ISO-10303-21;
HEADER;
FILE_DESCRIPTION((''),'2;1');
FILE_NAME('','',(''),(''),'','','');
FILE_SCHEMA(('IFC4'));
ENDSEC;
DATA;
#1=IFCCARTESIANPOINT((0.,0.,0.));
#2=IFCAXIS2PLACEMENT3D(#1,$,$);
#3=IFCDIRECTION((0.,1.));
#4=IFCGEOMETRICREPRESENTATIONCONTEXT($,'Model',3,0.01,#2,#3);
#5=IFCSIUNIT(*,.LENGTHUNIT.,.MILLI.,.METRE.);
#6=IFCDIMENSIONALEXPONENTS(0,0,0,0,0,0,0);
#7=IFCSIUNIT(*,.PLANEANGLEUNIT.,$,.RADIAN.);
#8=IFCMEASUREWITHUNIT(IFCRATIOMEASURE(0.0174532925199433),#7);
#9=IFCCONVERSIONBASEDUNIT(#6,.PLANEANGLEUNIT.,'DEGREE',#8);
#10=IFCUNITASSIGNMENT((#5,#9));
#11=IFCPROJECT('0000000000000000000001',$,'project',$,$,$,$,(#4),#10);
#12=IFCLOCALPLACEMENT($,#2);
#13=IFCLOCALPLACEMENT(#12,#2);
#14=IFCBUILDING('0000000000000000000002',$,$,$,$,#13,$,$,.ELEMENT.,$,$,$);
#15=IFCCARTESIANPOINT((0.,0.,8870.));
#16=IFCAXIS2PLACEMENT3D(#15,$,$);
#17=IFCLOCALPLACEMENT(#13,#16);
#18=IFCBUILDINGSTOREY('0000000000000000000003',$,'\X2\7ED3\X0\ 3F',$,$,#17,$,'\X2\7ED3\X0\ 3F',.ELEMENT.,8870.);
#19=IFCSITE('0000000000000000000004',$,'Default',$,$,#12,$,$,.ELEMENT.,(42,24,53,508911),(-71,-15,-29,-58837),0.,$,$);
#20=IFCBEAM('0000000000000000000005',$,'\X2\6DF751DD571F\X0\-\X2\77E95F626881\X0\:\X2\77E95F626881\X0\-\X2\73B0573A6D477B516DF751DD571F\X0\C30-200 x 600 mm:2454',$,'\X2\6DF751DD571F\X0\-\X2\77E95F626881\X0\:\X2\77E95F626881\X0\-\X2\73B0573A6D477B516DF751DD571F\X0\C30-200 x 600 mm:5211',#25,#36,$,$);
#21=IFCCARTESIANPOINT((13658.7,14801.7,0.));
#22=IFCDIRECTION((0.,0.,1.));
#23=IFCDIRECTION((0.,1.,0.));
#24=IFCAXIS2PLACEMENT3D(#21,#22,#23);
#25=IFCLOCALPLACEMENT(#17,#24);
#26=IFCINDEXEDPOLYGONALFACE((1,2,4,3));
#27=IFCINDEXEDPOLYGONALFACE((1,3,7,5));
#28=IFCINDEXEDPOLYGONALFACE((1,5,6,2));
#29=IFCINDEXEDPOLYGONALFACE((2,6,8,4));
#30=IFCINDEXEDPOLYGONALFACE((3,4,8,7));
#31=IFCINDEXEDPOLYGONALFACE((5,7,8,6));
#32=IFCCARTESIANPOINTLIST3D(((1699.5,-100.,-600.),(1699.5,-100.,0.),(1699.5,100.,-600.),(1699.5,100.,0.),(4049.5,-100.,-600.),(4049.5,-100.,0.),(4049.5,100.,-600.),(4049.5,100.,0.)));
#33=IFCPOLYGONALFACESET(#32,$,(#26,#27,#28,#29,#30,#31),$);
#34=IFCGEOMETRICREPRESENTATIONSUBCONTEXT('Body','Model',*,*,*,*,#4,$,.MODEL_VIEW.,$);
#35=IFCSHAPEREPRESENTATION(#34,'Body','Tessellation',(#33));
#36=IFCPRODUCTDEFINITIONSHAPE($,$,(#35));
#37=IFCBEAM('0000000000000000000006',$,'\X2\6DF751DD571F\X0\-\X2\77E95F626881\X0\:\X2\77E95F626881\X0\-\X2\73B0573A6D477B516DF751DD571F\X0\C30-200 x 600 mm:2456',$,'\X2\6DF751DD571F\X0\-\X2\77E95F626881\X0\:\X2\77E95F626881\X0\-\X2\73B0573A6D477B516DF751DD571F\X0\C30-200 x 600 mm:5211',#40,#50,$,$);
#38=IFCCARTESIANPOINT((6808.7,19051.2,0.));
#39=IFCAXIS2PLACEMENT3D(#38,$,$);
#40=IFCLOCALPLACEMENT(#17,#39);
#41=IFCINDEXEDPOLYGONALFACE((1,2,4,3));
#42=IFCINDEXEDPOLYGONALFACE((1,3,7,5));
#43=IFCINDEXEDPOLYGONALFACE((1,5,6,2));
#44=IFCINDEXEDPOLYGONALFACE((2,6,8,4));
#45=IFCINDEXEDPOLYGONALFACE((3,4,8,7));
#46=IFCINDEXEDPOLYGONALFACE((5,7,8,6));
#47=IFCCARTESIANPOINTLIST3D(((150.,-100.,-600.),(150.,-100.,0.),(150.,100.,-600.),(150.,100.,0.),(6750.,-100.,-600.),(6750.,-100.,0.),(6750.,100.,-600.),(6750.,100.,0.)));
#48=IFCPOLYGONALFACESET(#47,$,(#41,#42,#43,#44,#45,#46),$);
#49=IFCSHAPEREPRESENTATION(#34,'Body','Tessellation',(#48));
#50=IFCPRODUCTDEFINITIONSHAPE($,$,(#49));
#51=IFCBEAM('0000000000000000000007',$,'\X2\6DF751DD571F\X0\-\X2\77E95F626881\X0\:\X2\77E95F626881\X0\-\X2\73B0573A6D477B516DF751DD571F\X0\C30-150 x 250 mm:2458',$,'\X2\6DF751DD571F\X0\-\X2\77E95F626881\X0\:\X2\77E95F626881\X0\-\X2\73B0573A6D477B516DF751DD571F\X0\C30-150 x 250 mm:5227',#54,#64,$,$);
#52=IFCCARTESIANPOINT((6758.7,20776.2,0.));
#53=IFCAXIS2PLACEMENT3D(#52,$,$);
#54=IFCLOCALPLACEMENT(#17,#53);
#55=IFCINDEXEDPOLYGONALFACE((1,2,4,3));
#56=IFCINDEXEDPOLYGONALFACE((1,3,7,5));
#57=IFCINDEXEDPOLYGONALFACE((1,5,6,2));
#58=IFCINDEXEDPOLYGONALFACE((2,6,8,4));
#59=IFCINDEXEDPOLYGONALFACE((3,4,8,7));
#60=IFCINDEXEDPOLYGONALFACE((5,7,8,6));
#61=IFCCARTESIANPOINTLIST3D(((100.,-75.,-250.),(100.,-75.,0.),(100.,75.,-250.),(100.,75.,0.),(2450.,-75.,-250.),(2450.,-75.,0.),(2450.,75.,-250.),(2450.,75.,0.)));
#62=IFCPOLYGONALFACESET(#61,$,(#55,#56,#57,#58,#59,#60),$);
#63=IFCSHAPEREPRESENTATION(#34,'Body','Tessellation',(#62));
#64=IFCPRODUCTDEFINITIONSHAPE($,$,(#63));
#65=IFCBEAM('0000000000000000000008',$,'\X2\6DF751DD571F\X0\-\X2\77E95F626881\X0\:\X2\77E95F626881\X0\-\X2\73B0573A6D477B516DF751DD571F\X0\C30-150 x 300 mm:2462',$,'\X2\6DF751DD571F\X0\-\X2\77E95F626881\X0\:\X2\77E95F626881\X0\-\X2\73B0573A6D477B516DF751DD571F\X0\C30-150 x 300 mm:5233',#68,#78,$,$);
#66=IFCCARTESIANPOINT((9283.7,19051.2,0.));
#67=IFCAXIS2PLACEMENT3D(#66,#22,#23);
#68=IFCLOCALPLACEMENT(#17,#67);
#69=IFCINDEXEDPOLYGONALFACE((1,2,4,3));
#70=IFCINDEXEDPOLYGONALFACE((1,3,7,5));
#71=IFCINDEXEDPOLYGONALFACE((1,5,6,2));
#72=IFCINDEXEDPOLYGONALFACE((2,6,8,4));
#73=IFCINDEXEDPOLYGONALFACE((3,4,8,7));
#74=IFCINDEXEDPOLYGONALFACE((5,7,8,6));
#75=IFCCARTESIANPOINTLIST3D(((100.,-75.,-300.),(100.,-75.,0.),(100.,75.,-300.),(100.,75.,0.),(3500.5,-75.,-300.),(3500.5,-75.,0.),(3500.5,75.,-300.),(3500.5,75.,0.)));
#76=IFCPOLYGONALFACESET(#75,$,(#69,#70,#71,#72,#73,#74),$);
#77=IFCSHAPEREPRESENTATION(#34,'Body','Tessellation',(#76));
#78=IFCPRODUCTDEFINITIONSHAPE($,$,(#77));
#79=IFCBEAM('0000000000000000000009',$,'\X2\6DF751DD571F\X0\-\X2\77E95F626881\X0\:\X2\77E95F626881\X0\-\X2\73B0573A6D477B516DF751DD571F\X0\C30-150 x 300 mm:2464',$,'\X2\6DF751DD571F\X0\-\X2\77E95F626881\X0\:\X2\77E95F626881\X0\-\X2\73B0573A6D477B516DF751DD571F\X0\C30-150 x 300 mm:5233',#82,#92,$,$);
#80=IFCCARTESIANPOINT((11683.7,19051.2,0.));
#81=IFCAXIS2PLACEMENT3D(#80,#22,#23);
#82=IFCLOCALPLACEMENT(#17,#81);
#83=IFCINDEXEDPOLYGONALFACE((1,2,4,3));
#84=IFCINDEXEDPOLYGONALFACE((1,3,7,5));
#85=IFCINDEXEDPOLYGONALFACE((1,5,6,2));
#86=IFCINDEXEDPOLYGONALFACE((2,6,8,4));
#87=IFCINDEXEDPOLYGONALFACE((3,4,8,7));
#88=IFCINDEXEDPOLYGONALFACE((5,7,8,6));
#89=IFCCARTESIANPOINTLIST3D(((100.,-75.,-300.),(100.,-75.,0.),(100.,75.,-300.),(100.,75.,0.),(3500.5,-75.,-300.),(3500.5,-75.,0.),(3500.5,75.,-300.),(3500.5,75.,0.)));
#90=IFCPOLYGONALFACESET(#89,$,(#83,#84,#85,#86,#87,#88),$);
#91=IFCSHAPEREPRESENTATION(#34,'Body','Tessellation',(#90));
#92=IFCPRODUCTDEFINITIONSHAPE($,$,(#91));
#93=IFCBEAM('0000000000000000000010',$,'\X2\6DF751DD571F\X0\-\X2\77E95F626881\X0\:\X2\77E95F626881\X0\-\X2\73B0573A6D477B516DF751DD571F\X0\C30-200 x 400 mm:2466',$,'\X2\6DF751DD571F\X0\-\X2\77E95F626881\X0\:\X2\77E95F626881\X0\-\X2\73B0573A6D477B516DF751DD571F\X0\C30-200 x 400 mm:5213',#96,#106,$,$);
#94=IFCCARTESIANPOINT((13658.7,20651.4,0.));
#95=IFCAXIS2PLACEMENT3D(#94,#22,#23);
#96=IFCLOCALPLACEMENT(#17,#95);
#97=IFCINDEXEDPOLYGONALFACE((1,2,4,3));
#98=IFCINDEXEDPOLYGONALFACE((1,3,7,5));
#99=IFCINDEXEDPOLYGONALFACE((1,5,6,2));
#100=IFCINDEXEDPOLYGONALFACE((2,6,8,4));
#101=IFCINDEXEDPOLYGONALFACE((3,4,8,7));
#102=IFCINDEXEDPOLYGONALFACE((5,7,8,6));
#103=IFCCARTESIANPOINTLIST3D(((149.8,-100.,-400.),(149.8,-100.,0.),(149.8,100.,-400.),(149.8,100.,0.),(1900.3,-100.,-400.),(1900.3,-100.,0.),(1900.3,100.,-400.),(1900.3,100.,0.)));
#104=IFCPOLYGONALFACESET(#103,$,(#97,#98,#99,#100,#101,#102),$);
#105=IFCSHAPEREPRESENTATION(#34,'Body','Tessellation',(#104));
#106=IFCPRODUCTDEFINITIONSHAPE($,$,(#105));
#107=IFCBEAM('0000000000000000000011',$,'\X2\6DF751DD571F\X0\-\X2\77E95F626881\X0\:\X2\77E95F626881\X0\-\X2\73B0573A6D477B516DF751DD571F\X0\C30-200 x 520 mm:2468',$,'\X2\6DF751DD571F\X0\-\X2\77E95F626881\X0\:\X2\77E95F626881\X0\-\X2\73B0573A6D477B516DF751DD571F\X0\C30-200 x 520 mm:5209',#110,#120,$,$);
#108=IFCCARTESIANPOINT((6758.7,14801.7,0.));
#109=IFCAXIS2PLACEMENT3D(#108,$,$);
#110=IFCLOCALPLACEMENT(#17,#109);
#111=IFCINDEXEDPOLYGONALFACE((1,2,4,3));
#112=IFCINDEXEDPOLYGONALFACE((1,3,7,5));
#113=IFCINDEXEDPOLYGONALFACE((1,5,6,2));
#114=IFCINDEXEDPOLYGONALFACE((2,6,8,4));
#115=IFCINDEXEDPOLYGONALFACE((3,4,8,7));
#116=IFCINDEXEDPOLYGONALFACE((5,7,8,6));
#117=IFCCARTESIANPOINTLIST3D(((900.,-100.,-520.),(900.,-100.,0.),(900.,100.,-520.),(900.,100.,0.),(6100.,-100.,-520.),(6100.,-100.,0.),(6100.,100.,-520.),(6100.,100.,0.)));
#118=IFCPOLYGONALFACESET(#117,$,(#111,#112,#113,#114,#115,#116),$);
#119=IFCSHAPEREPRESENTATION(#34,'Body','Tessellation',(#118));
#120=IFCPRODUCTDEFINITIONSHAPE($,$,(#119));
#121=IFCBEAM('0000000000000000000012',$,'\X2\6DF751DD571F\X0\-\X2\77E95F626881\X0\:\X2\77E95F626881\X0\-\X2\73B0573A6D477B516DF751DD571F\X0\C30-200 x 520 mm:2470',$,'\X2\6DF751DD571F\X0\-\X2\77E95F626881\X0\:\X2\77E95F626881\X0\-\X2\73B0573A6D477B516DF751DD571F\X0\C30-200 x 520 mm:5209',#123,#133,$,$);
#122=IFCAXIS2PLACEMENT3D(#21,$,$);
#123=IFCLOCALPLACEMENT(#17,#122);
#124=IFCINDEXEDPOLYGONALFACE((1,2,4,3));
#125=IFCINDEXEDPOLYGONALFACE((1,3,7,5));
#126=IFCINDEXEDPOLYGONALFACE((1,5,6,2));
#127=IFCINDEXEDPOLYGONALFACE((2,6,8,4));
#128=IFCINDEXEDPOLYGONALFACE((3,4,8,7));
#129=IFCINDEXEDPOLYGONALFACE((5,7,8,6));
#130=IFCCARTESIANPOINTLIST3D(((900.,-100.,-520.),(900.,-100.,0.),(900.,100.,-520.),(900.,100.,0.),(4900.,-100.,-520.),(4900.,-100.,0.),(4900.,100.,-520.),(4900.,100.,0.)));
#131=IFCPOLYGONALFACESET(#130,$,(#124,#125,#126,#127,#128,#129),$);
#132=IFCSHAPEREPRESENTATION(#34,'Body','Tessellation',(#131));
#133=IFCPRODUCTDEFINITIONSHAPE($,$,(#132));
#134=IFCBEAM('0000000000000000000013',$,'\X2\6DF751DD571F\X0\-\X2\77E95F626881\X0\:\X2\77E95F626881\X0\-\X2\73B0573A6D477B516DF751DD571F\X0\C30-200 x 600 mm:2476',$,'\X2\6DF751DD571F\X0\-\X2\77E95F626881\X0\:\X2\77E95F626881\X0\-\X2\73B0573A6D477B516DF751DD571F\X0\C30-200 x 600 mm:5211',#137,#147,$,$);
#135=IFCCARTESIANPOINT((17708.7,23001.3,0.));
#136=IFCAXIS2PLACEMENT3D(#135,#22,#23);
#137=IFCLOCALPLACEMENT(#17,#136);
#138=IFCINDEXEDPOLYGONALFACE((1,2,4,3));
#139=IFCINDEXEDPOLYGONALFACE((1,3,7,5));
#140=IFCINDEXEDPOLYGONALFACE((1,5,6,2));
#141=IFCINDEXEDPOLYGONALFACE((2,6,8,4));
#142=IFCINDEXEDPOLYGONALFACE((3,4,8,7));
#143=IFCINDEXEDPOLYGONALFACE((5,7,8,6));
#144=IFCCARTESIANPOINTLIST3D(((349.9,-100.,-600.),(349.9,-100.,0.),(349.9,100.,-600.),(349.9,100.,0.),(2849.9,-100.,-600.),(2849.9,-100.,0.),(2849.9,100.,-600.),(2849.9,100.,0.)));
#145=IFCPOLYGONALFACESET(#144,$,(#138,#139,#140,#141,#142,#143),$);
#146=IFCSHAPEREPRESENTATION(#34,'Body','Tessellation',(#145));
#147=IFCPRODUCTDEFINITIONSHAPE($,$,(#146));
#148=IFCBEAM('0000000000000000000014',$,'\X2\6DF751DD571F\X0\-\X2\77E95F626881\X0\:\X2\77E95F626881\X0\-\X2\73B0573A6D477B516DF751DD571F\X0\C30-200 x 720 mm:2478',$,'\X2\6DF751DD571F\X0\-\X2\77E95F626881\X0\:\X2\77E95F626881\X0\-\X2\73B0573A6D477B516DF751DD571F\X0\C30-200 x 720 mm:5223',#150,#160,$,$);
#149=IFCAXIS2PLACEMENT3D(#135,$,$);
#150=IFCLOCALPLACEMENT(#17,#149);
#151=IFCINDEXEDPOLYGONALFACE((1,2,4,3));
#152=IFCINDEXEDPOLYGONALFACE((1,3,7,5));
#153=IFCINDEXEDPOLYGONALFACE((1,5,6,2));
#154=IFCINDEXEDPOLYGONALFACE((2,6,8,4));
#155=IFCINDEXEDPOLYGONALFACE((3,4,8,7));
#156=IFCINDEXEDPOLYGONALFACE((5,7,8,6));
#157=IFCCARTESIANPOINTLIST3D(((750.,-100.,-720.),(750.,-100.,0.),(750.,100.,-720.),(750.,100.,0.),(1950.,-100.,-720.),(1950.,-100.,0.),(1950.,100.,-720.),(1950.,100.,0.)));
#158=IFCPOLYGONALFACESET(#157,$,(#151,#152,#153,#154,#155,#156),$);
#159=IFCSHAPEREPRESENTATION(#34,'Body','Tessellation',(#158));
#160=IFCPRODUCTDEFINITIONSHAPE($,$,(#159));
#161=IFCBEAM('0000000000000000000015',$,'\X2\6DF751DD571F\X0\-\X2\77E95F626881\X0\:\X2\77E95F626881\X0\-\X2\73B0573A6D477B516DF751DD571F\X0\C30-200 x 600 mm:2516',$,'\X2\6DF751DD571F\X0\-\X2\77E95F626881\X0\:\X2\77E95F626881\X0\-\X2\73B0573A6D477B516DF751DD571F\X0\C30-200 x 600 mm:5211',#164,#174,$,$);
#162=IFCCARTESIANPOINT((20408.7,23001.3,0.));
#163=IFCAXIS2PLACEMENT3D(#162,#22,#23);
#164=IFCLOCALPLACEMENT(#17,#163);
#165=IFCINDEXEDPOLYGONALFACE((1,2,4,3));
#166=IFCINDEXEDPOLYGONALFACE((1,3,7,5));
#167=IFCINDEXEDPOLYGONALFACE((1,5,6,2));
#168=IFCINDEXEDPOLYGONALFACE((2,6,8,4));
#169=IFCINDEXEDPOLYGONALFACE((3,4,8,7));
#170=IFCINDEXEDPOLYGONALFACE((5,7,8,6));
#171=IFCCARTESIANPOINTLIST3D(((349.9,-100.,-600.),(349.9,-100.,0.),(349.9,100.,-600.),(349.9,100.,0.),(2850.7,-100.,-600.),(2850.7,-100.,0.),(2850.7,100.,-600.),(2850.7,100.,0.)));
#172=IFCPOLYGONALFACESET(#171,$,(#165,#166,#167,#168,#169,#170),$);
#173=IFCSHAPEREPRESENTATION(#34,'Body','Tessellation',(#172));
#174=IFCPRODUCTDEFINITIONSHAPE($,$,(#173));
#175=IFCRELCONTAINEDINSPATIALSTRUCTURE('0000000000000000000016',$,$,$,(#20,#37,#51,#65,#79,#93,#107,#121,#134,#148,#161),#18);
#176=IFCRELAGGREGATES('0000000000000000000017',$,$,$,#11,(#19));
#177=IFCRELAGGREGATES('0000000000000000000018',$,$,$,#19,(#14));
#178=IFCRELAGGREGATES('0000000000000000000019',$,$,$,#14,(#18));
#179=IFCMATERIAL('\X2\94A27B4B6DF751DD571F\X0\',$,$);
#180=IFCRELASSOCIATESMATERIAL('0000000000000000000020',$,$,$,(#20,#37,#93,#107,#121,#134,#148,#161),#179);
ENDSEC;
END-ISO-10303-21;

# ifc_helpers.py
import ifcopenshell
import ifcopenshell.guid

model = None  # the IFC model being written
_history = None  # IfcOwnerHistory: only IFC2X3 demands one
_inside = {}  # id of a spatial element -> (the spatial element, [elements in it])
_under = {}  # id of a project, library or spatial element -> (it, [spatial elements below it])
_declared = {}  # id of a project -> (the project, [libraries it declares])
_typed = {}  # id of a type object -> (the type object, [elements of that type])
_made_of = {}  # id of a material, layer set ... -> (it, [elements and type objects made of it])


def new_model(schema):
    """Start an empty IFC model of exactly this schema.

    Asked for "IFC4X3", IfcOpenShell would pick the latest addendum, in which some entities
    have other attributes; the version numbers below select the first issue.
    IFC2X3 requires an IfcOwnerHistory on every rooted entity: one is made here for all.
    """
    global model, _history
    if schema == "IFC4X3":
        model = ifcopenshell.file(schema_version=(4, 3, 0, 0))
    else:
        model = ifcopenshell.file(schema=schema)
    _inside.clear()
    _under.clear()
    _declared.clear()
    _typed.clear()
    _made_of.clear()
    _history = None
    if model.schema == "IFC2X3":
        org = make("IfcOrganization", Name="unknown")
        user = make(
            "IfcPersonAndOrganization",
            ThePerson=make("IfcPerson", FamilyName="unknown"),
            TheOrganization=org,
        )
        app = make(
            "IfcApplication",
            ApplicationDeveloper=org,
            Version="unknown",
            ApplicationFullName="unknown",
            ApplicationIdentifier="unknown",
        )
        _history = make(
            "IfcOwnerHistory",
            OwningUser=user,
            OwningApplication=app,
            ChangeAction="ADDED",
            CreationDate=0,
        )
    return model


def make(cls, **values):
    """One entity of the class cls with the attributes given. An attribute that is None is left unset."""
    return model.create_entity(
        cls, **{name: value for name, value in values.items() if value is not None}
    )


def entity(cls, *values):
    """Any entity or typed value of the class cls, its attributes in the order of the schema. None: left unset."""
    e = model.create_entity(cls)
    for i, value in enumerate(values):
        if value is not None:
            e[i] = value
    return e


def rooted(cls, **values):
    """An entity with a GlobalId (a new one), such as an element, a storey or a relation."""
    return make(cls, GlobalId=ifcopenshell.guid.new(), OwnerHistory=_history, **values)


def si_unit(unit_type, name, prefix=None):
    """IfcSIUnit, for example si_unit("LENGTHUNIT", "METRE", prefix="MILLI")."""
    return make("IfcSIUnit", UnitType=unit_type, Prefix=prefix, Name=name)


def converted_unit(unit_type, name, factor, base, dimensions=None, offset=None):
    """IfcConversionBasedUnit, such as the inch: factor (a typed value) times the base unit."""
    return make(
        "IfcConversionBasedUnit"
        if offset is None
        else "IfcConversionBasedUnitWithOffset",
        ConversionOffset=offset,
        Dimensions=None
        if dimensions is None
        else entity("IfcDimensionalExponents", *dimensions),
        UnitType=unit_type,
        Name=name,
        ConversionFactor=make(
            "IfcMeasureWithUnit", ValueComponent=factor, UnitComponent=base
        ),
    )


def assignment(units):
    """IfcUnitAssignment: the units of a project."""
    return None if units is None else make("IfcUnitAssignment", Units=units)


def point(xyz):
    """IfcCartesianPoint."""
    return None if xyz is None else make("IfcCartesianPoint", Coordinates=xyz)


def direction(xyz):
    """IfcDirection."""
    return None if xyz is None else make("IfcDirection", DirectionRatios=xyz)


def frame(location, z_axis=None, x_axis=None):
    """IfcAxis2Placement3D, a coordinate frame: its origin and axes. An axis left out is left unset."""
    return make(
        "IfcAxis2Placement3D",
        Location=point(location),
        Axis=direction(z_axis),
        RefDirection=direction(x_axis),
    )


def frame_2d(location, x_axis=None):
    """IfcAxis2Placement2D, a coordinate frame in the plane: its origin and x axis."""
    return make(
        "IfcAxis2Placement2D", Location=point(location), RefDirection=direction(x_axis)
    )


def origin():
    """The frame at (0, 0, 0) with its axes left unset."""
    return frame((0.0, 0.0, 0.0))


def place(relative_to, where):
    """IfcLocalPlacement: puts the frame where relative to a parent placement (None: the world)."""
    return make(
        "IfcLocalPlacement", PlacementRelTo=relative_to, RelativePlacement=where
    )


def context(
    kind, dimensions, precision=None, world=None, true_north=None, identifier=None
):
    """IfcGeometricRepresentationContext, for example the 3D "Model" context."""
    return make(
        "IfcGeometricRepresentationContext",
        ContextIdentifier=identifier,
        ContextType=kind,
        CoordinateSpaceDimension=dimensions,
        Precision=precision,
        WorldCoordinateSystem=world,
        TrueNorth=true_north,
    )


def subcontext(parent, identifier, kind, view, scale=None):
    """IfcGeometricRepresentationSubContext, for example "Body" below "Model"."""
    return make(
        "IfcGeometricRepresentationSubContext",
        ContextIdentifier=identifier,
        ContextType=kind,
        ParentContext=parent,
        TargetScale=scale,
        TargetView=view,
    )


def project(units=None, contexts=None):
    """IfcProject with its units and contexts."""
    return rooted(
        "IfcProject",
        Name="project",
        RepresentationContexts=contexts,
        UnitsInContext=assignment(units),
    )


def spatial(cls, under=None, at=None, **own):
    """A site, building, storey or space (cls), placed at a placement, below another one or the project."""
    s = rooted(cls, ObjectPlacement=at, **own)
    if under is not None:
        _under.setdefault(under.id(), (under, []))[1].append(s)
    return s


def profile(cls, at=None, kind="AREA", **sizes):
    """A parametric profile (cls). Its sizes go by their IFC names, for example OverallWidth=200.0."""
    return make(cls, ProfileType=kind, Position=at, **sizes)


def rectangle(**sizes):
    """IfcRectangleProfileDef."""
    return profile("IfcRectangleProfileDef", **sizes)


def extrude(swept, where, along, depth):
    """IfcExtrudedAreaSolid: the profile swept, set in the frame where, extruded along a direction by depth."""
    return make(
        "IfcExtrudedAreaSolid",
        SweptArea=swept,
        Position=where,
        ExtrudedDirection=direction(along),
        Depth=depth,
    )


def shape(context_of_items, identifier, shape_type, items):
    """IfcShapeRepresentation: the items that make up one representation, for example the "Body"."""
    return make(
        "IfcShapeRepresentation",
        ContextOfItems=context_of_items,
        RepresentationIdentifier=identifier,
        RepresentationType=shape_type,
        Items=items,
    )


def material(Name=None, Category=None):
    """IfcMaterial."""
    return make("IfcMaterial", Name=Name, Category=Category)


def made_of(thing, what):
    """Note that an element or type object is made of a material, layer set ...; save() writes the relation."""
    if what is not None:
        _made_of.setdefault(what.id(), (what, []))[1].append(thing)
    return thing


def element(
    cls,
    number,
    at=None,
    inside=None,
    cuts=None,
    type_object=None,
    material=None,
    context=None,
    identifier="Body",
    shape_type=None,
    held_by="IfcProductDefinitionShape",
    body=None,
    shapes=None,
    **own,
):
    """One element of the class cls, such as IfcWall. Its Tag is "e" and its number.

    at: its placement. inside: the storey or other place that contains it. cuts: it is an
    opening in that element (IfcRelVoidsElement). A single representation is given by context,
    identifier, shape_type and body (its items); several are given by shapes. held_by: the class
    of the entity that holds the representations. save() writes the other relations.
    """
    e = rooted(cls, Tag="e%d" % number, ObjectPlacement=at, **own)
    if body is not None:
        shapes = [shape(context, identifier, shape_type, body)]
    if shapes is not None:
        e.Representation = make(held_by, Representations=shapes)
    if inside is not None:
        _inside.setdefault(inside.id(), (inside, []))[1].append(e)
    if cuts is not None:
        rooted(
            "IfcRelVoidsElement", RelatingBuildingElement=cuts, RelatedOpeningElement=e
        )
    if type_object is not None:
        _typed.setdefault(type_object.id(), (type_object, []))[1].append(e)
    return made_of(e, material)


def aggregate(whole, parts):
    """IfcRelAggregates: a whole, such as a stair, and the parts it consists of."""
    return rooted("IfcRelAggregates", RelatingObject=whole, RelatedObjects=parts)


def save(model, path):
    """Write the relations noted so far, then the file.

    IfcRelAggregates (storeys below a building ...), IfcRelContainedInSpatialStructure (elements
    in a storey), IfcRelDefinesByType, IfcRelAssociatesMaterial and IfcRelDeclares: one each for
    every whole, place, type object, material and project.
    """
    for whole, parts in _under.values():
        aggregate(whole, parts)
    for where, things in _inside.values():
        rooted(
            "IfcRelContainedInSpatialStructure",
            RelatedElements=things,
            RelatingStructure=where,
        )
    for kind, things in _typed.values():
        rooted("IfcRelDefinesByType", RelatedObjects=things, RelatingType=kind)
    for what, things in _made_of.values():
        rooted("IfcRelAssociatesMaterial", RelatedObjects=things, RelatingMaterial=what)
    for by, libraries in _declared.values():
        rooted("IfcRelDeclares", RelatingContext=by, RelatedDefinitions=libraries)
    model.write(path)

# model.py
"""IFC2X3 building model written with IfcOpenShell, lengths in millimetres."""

from ifc_helpers import new_model, entity, si_unit, converted_unit, direction, frame, frame_2d, origin, place, context, subcontext, project, spatial, rectangle, extrude, material, element, save


model = new_model("IFC2X3")

# Units and contexts
model_context = context("Model", 3, precision=0.01, world=origin(), true_north=direction((0.0, 1.0)))
body_context = subcontext(model_context, "Body", "Model", "MODEL_VIEW")
ifc_project = project(units=[si_unit("LENGTHUNIT", "METRE", prefix="MILLI"), converted_unit("PLANEANGLEUNIT", "DEGREE", entity("IfcRatioMeasure", 0.0174532925199433), si_unit("PLANEANGLEUNIT", "RADIAN"), dimensions=[0, 0, 0, 0, 0, 0, 0])], contexts=[model_context])

# Site, building, storey
site_placement = place(None, origin())
site = spatial("IfcSite", under=ifc_project, at=site_placement, Name="Default", CompositionType="ELEMENT", RefLatitude=(42, 24, 53, 508911), RefLongitude=(-71, -15, -29, -58837), RefElevation=0.0)
building_placement = place(site_placement, origin())
building = spatial("IfcBuilding", under=site, at=building_placement, CompositionType="ELEMENT")
storey_placement = place(building_placement, frame((0.0, 0.0, 8870.0)))
storey = spatial("IfcBuildingStorey", under=building, at=storey_placement, Name="结 3F", LongName="结 3F", CompositionType="ELEMENT", Elevation=8870.0)

# Beams
ifc_material = material(Name="钢筋混凝土")
beam_1_placement = place(storey_placement, frame((13658.7, 14801.7, 0.0), z_axis=(0.0, 0.0, 1.0), x_axis=(0.0, 1.0, 0.0)))
element("IfcBeam", 1, at=beam_1_placement, inside=storey, material=ifc_material, Name="混凝土-矩形梁:矩形梁-现场浇筑混凝土C30-200 x 600 mm:2454", ObjectType="混凝土-矩形梁:矩形梁-现场浇筑混凝土C30-200 x 600 mm:5211", context=body_context, shape_type="SweptSolid", body=[
    extrude(rectangle(XDim=600.0, YDim=200.0, at=frame_2d((0.0, 0.0), x_axis=(1.0, 0.0))), frame((1699.5, 0.0, -300.0), z_axis=(1.0, 0.0, 0.0), x_axis=(0.0, 0.0, -1.0)), (0.0, 0.0, 1.0), 2350.0),
])
beam_2_placement = place(storey_placement, frame((6808.7, 19051.2, 0.0)))
element("IfcBeam", 2, at=beam_2_placement, inside=storey, material=ifc_material, Name="混凝土-矩形梁:矩形梁-现场浇筑混凝土C30-200 x 600 mm:2456", ObjectType="混凝土-矩形梁:矩形梁-现场浇筑混凝土C30-200 x 600 mm:5211", context=body_context, shape_type="SweptSolid", body=[
    extrude(rectangle(XDim=600.0, YDim=200.0, at=frame_2d((0.0, 0.0), x_axis=(1.0, 0.0))), frame((150.0, 0.0, -300.0), z_axis=(1.0, 0.0, 0.0), x_axis=(0.0, 0.0, -1.0)), (0.0, 0.0, 1.0), 6600.0),
])
beam_3_placement = place(storey_placement, frame((6758.7, 20776.2, 0.0)))
element("IfcBeam", 3, at=beam_3_placement, inside=storey, Name="混凝土-矩形梁:矩形梁-现场浇筑混凝土C30-150 x 250 mm:2458", ObjectType="混凝土-矩形梁:矩形梁-现场浇筑混凝土C30-150 x 250 mm:5227", context=body_context, shape_type="SweptSolid", body=[
    extrude(rectangle(XDim=250.0, YDim=150.0, at=frame_2d((0.0, 0.0), x_axis=(1.0, 0.0))), frame((100.0, 0.0, -125.0), z_axis=(1.0, 0.0, 0.0), x_axis=(0.0, 0.0, -1.0)), (0.0, 0.0, 1.0), 2350.0),
])
beam_4_placement = place(storey_placement, frame((9283.7, 19051.2, 0.0), z_axis=(0.0, 0.0, 1.0), x_axis=(0.0, 1.0, 0.0)))
element("IfcBeam", 4, at=beam_4_placement, inside=storey, Name="混凝土-矩形梁:矩形梁-现场浇筑混凝土C30-150 x 300 mm:2462", ObjectType="混凝土-矩形梁:矩形梁-现场浇筑混凝土C30-150 x 300 mm:5233", context=body_context, shape_type="SweptSolid", body=[
    extrude(rectangle(XDim=300.0, YDim=150.0, at=frame_2d((0.0, 0.0), x_axis=(1.0, 0.0))), frame((100.0, 0.0, -150.0), z_axis=(1.0, 0.0, 0.0), x_axis=(0.0, 0.0, -1.0)), (0.0, 0.0, 1.0), 3400.5),
])
beam_5_placement = place(storey_placement, frame((11683.7, 19051.2, 0.0), z_axis=(0.0, 0.0, 1.0), x_axis=(0.0, 1.0, 0.0)))
element("IfcBeam", 5, at=beam_5_placement, inside=storey, Name="混凝土-矩形梁:矩形梁-现场浇筑混凝土C30-150 x 300 mm:2464", ObjectType="混凝土-矩形梁:矩形梁-现场浇筑混凝土C30-150 x 300 mm:5233", context=body_context, shape_type="SweptSolid", body=[
    extrude(rectangle(XDim=300.0, YDim=150.0, at=frame_2d((0.0, 0.0), x_axis=(1.0, 0.0))), frame((100.0, 0.0, -150.0), z_axis=(1.0, 0.0, 0.0), x_axis=(0.0, 0.0, -1.0)), (0.0, 0.0, 1.0), 3400.5),
])
beam_6_placement = place(storey_placement, frame((13658.7, 20651.4, 0.0), z_axis=(0.0, 0.0, 1.0), x_axis=(0.0, 1.0, 0.0)))
element("IfcBeam", 6, at=beam_6_placement, inside=storey, material=ifc_material, Name="混凝土-矩形梁:矩形梁-现场浇筑混凝土C30-200 x 400 mm:2466", ObjectType="混凝土-矩形梁:矩形梁-现场浇筑混凝土C30-200 x 400 mm:5213", context=body_context, shape_type="SweptSolid", body=[
    extrude(rectangle(XDim=400.0, YDim=200.0, at=frame_2d((0.0, 0.0), x_axis=(1.0, 0.0))), frame((149.8, 0.0, -200.0), z_axis=(1.0, 0.0, 0.0), x_axis=(0.0, 0.0, -1.0)), (0.0, 0.0, 1.0), 1750.5),
])
beam_7_placement = place(storey_placement, frame((6758.7, 14801.7, 0.0)))
element("IfcBeam", 7, at=beam_7_placement, inside=storey, material=ifc_material, Name="混凝土-矩形梁:矩形梁-现场浇筑混凝土C30-200 x 520 mm:2468", ObjectType="混凝土-矩形梁:矩形梁-现场浇筑混凝土C30-200 x 520 mm:5209", context=body_context, shape_type="SweptSolid", body=[
    extrude(rectangle(XDim=520.0, YDim=200.0, at=frame_2d((0.0, 0.0), x_axis=(1.0, 0.0))), frame((900.0, 0.0, -260.0), z_axis=(1.0, 0.0, 0.0), x_axis=(0.0, 0.0, -1.0)), (0.0, 0.0, 1.0), 5200.0),
])
beam_8_placement = place(storey_placement, frame((13658.7, 14801.7, 0.0)))
element("IfcBeam", 8, at=beam_8_placement, inside=storey, material=ifc_material, Name="混凝土-矩形梁:矩形梁-现场浇筑混凝土C30-200 x 520 mm:2470", ObjectType="混凝土-矩形梁:矩形梁-现场浇筑混凝土C30-200 x 520 mm:5209", context=body_context, shape_type="SweptSolid", body=[
    extrude(rectangle(XDim=520.0, YDim=200.0, at=frame_2d((0.0, 0.0), x_axis=(1.0, 0.0))), frame((900.0, 0.0, -260.0), z_axis=(1.0, 0.0, 0.0), x_axis=(0.0, 0.0, -1.0)), (0.0, 0.0, 1.0), 4000.0),
])
beam_9_placement = place(storey_placement, frame((17708.7, 23001.3, 0.0), z_axis=(0.0, 0.0, 1.0), x_axis=(0.0, 1.0, 0.0)))
element("IfcBeam", 9, at=beam_9_placement, inside=storey, material=ifc_material, Name="混凝土-矩形梁:矩形梁-现场浇筑混凝土C30-200 x 600 mm:2476", ObjectType="混凝土-矩形梁:矩形梁-现场浇筑混凝土C30-200 x 600 mm:5211", context=body_context, shape_type="SweptSolid", body=[
    extrude(rectangle(XDim=600.0, YDim=200.0, at=frame_2d((0.0, 0.0), x_axis=(1.0, 0.0))), frame((349.9, 0.0, -300.0), z_axis=(1.0, 0.0, 0.0), x_axis=(0.0, 0.0, -1.0)), (0.0, 0.0, 1.0), 2500.0),
])
beam_10_placement = place(storey_placement, frame((17708.7, 23001.3, 0.0)))
element("IfcBeam", 10, at=beam_10_placement, inside=storey, material=ifc_material, Name="混凝土-矩形梁:矩形梁-现场浇筑混凝土C30-200 x 720 mm:2478", ObjectType="混凝土-矩形梁:矩形梁-现场浇筑混凝土C30-200 x 720 mm:5223", context=body_context, shape_type="SweptSolid", body=[
    extrude(rectangle(XDim=720.0, YDim=200.0, at=frame_2d((0.0, 0.0), x_axis=(1.0, 0.0))), frame((750.0, 0.0, -360.0), z_axis=(1.0, 0.0, 0.0), x_axis=(0.0, 0.0, -1.0)), (0.0, 0.0, 1.0), 1200.0),
])
beam_11_placement = place(storey_placement, frame((20408.7, 23001.3, 0.0), z_axis=(0.0, 0.0, 1.0), x_axis=(0.0, 1.0, 0.0)))
element("IfcBeam", 11, at=beam_11_placement, inside=storey, material=ifc_material, Name="混凝土-矩形梁:矩形梁-现场浇筑混凝土C30-200 x 600 mm:2516", ObjectType="混凝土-矩形梁:矩形梁-现场浇筑混凝土C30-200 x 600 mm:5211", context=body_context, shape_type="SweptSolid", body=[
    extrude(rectangle(XDim=600.0, YDim=200.0, at=frame_2d((0.0, 0.0), x_axis=(1.0, 0.0))), frame((349.9, 0.0, -300.0), z_axis=(1.0, 0.0, 0.0), x_axis=(0.0, 0.0, -1.0)), (0.0, 0.0, 1.0), 2500.8),
])

save(model, "model.ifc")
